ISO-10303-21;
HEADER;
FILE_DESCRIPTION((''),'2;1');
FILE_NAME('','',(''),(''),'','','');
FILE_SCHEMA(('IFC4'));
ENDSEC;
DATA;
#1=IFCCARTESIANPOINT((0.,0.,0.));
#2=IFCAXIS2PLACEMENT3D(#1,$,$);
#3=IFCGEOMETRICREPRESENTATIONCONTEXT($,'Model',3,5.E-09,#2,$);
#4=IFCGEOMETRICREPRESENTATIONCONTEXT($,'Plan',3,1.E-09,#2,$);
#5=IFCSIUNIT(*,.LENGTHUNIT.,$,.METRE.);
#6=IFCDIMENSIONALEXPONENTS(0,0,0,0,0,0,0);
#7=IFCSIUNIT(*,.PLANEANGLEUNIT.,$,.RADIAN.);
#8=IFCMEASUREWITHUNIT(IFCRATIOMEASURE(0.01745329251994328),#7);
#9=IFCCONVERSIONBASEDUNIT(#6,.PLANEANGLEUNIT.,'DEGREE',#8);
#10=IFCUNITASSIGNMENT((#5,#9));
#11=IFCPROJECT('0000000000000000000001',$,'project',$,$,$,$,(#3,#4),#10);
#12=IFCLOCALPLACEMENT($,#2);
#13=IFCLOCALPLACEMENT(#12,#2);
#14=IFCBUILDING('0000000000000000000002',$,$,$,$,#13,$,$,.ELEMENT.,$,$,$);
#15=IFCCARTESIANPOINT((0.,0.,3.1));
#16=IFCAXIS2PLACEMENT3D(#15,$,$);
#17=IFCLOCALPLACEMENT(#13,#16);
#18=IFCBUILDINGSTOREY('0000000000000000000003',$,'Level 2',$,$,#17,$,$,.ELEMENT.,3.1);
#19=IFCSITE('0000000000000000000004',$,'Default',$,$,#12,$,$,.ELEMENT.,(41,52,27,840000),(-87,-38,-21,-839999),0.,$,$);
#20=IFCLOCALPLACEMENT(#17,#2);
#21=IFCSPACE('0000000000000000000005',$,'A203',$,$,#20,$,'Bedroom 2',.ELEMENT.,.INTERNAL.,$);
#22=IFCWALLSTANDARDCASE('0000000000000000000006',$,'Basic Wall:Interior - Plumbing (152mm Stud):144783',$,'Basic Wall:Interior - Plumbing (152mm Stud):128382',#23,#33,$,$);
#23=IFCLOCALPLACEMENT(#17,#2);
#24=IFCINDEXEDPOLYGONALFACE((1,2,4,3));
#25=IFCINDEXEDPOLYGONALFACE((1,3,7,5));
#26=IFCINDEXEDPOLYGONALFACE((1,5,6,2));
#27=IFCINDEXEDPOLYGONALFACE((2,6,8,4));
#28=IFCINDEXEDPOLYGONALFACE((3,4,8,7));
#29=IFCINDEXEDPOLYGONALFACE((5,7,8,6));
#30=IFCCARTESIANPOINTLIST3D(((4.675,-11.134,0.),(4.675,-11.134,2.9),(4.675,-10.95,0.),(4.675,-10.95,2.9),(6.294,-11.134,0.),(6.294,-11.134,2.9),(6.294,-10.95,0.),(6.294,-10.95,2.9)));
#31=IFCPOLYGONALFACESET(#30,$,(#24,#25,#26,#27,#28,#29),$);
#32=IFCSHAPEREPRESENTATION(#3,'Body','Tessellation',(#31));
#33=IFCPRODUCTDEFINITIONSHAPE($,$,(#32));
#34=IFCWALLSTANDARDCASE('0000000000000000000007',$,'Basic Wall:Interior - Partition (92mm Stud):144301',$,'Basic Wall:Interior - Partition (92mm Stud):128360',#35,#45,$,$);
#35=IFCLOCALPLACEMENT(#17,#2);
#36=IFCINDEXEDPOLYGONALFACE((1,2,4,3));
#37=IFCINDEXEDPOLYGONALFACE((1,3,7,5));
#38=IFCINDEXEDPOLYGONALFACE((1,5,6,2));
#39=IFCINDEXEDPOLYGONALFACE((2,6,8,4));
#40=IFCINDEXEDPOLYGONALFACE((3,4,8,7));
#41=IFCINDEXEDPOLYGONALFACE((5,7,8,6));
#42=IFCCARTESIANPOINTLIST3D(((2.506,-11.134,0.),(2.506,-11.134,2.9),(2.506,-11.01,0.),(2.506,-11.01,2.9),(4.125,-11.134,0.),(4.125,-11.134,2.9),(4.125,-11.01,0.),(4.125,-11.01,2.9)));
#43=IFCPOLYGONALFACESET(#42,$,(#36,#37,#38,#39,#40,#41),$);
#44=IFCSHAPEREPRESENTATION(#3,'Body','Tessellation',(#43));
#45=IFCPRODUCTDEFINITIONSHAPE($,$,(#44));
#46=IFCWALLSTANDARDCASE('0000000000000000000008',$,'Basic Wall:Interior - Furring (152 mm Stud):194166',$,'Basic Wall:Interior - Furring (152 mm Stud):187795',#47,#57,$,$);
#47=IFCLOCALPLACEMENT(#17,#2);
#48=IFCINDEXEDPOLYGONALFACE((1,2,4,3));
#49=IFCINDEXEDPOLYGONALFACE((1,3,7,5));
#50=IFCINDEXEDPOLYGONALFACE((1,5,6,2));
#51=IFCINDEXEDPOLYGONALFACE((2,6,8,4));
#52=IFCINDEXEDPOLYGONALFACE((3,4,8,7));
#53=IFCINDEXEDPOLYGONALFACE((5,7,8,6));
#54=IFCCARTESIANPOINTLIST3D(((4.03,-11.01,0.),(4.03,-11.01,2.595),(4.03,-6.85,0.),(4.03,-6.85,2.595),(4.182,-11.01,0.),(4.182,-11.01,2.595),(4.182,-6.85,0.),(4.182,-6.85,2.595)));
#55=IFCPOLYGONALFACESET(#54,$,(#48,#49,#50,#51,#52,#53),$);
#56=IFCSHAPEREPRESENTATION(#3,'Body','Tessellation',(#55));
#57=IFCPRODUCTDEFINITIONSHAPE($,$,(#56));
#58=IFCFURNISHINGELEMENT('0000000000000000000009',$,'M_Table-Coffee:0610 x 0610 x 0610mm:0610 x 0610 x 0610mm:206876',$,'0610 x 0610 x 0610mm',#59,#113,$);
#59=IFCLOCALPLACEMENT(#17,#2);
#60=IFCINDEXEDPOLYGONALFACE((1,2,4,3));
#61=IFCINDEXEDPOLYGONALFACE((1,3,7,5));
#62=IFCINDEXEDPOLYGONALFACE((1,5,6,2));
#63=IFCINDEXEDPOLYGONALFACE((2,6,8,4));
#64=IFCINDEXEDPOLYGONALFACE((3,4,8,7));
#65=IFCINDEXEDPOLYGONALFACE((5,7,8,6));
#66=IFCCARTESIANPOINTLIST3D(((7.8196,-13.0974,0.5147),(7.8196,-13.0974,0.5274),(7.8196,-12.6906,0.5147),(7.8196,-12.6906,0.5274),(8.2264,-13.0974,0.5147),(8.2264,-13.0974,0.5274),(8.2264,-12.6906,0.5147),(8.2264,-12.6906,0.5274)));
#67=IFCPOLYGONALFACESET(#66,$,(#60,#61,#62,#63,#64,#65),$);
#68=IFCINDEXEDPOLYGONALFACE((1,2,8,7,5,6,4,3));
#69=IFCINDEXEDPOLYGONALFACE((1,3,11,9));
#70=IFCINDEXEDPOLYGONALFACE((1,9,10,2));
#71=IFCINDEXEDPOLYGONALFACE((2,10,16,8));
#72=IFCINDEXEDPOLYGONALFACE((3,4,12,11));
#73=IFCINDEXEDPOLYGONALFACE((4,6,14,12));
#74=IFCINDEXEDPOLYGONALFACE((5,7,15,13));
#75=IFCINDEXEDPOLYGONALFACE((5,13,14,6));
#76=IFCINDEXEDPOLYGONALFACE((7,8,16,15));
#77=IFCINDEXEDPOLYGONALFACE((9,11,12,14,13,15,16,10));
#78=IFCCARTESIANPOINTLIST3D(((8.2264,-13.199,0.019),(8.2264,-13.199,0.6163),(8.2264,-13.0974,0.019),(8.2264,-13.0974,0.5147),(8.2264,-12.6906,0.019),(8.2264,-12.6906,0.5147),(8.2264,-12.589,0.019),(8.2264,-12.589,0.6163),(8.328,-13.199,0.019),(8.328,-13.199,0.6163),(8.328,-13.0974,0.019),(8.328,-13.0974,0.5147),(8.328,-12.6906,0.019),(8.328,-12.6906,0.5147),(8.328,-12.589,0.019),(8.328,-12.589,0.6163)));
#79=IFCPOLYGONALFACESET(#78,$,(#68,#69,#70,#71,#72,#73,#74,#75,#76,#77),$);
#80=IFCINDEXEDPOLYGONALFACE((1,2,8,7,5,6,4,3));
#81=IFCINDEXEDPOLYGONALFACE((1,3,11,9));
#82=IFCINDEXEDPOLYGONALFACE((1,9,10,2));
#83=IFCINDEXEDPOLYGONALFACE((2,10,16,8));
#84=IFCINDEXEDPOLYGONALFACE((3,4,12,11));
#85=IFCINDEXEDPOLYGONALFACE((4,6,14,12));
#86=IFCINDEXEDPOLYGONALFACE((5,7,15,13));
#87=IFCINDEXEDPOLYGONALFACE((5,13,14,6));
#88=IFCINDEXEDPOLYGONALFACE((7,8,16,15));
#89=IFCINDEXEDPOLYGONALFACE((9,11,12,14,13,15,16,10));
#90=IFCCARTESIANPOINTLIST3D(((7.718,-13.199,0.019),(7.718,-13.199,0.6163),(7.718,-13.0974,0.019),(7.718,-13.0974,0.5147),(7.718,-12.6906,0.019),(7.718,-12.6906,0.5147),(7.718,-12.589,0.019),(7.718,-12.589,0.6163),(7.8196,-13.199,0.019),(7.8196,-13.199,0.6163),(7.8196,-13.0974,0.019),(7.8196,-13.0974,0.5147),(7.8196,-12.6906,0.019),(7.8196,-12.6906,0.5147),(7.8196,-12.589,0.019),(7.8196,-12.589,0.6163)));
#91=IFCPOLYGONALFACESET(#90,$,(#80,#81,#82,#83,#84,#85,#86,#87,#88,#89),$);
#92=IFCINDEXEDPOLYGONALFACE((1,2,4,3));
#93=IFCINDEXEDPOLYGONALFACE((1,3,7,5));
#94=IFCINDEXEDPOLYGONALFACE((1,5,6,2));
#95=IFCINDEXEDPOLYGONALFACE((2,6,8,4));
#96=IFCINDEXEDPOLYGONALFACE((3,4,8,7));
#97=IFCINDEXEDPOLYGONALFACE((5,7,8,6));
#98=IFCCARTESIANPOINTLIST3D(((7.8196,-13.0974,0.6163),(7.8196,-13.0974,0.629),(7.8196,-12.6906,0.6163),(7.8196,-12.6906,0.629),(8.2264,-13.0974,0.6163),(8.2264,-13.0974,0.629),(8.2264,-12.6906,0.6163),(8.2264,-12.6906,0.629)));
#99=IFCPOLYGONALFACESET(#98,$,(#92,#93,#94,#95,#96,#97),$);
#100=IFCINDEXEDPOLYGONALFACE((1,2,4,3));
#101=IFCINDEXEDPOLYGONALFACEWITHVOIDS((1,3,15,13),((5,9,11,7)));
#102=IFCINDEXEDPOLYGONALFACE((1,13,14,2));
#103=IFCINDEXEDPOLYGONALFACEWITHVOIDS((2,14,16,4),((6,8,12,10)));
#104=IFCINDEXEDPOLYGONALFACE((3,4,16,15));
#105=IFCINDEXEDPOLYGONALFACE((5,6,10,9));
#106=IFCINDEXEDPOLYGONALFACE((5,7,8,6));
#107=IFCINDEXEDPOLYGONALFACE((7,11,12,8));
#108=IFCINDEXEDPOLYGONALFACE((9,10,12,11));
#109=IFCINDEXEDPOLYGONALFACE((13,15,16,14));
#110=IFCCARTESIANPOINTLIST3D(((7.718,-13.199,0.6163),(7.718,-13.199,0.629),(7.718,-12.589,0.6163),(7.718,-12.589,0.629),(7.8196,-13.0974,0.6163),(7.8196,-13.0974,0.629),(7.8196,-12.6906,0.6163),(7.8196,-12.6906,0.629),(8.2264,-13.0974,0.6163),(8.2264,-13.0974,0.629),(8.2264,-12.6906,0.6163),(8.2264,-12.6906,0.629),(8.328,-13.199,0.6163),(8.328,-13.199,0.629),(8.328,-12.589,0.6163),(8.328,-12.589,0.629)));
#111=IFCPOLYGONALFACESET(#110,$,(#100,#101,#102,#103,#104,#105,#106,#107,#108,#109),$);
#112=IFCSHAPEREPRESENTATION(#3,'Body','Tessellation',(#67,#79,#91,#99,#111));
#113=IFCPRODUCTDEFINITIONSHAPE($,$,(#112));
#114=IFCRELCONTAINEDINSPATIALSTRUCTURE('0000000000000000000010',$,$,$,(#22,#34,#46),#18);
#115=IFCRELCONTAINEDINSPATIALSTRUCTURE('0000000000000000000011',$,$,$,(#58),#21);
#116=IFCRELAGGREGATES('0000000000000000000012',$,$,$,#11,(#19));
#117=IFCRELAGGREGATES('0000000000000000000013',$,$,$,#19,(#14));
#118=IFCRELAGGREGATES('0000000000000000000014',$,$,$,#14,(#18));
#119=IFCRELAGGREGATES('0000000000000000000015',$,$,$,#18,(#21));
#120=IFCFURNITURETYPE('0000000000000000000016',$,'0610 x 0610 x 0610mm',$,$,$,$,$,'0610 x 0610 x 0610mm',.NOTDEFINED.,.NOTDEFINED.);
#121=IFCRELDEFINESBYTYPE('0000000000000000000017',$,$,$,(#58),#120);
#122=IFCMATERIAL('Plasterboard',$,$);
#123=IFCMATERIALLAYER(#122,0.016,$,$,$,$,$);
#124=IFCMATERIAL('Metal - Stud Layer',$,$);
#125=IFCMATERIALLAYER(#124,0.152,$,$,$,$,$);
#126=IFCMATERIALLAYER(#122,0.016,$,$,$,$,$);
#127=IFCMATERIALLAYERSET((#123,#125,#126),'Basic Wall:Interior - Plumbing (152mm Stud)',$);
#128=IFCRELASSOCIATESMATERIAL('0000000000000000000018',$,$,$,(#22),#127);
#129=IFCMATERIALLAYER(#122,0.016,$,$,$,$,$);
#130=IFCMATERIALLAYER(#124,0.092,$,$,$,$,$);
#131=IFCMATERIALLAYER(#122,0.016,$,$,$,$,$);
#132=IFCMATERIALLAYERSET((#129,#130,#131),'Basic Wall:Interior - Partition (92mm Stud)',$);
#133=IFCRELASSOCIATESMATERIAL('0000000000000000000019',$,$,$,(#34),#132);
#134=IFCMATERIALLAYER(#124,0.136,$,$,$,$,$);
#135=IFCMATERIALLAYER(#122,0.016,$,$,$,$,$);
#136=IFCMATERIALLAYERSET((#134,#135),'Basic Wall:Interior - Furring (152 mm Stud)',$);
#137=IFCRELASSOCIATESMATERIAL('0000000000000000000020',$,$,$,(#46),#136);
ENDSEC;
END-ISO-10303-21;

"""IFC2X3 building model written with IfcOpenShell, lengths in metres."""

from ifc_helpers import new_model, entity, si_unit, converted_unit, frame, frame_2d, origin, origin_2d_with_axis, place, context, project, spatial, polyline, rectangle, outline, extrude, source, transform, mapped, material, layer, layer_set, layer_usage, type_object, type_shapes, element, save


model = new_model("IFC2X3")

# Units and contexts
model_context = context("Model", 3, precision=5e-09, world=origin())
plan_context = context("Plan", 3, precision=1e-09, world=origin())
ifc_project = project(units=[si_unit("LENGTHUNIT", "METRE"), converted_unit("PLANEANGLEUNIT", "DEGREE", entity("IfcRatioMeasure", 0.01745329251994328), si_unit("PLANEANGLEUNIT", "RADIAN"), dimensions=[0, 0, 0, 0, 0, 0, 0])], contexts=[model_context, plan_context])

# Site, building, storey
site_placement = place(None, origin())
site = spatial("IfcSite", under=ifc_project, at=site_placement, Name="Default", CompositionType="ELEMENT", RefLatitude=(41, 52, 27, 840000), RefLongitude=(-87, -38, -21, -839999), RefElevation=0.0)
building_placement = place(site_placement, origin())
building = spatial("IfcBuilding", under=site, at=building_placement, CompositionType="ELEMENT")
storey_placement = place(building_placement, frame((0.0, 0.0, 3.1)))
storey = spatial("IfcBuildingStorey", under=building, at=storey_placement, Name="Level 2", CompositionType="ELEMENT", Elevation=3.1)

# Shared definitions
ifc_material_1 = material(Name="Plasterboard")
ifc_layer_1 = layer(ifc_material_1, 0.016)
ifc_material_2 = material(Name="Metal - Stud Layer")
ifc_layer_2 = layer(ifc_material_2, 0.092)
ifc_layer_3 = layer(ifc_material_1, 0.016)
ifc_layer_set_1 = layer_set([ifc_layer_1, ifc_layer_2, ifc_layer_3], Name="Basic Wall:Interior - Partition (92mm Stud)")
ifc_layer_usage_1 = layer_usage(ifc_layer_set_1, "AXIS2", "NEGATIVE", 0.062)

# Walls
ifc_layer_4 = layer(ifc_material_1, 0.016)
ifc_layer_5 = layer(ifc_material_2, 0.152)
ifc_layer_6 = layer(ifc_material_1, 0.016)
ifc_layer_set_2 = layer_set([ifc_layer_4, ifc_layer_5, ifc_layer_6], Name="Basic Wall:Interior - Plumbing (152mm Stud)")
ifc_layer_usage_2 = layer_usage(ifc_layer_set_2, "AXIS2", "NEGATIVE", 0.092)
wall_1_placement = place(storey_placement, frame((6.294, -11.042, 0.0), z_axis=(0.0, 0.0, 1.0), x_axis=(-1.0, 0.0, 0.0)))
element("IfcWallStandardCase", 1, at=wall_1_placement, inside=storey, material=ifc_layer_usage_2, Name="Basic Wall:Interior - Plumbing (152mm Stud):144783", ObjectType="Basic Wall:Interior - Plumbing (152mm Stud):128382", context=model_context, shape_type="SweptSolid", body=[
    extrude(rectangle(XDim=1.619, YDim=0.184, at=frame_2d((0.8095, 0.0), x_axis=(-1.0, 0.0))), origin(), (0.0, 0.0, 1.0), 2.9),
])
wall_2_placement = place(storey_placement, frame((4.125, -11.072, 0.0), z_axis=(0.0, 0.0, 1.0), x_axis=(-1.0, 0.0, 0.0)))
element("IfcWallStandardCase", 2, at=wall_2_placement, inside=storey, material=ifc_layer_usage_1, Name="Basic Wall:Interior - Partition (92mm Stud):144301", ObjectType="Basic Wall:Interior - Partition (92mm Stud):128360", context=model_context, shape_type="SweptSolid", body=[
    extrude(rectangle(XDim=1.619, YDim=0.124, at=frame_2d((0.8095, 0.0), x_axis=(-1.0, 0.0))), origin(), (0.0, 0.0, 1.0), 2.9),
])
ifc_layer_7 = layer(ifc_material_2, 0.136)
ifc_layer_8 = layer(ifc_material_1, 0.016)
ifc_layer_set_3 = layer_set([ifc_layer_7, ifc_layer_8], Name="Basic Wall:Interior - Furring (152 mm Stud)")
ifc_layer_usage_3 = layer_usage(ifc_layer_set_3, "AXIS2", "POSITIVE", -0.076)
wall_3_placement = place(storey_placement, frame((4.106, -11.01, 0.0), z_axis=(0.0, 0.0, 1.0), x_axis=(0.0, 1.0, 0.0)))
element("IfcWallStandardCase", 3, at=wall_3_placement, inside=storey, material=ifc_layer_usage_3, Name="Basic Wall:Interior - Furring (152 mm Stud):194166", ObjectType="Basic Wall:Interior - Furring (152 mm Stud):187795", context=model_context, shape_type="SweptSolid", body=[
    extrude(rectangle(XDim=4.16, YDim=0.152, at=frame_2d((2.08, 0.0), x_axis=(-1.0, 0.0))), origin(), (0.0, 0.0, 1.0), 2.595),
])

# Shared definitions
space_placement = place(storey_placement, origin())
space = spatial("IfcSpace", under=storey, at=space_placement, Name="A203", LongName="Bedroom 2", CompositionType="ELEMENT", InteriorOrExteriorSpace="INTERNAL")

# Furnishing element
furniture_type = type_object("IfcFurnitureType", Name="0610 x 0610 x 0610mm", ElementType="0610 x 0610 x 0610mm", AssemblyPlace="NOTDEFINED")
shared_shape_1 = source(origin(), model_context, "Body", "SweptSolid", [
    extrude(rectangle(XDim=0.4068, YDim=0.4068, at=origin_2d_with_axis()), frame((0.0183, 0.0952, 0.4957), z_axis=(0.0, 0.0, 1.0), x_axis=(-1.0, 0.0, 0.0)), (0.0, 0.0, 1.0), 0.0127),
    extrude(outline(polyline([(-0.2732, -0.305), (0.324, -0.305), (0.324, 0.305), (-0.2732, 0.305), (-0.2732, 0.2034), (0.2225, 0.2034), (0.2225, -0.2034), (-0.2732, -0.2034), (-0.2732, -0.305)])), frame((0.2217, 0.0952, 0.2732), z_axis=(1.0, 0.0, 0.0), x_axis=(0.0, 0.0, 1.0)), (0.0, 0.0, 1.0), 0.1016),
    extrude(outline(polyline([(-0.305, -0.3241), (0.305, -0.3241), (0.305, 0.2733), (0.2034, 0.2733), (0.2034, -0.2224), (-0.2034, -0.2224), (-0.2034, 0.2733), (-0.305, 0.2733), (-0.305, -0.3241)])), frame((-0.2867, 0.0952, 0.2733), z_axis=(1.0, 0.0, 0.0), x_axis=(0.0, -1.0, 0.0)), (0.0, 0.0, 1.0), 0.1016),
    extrude(rectangle(XDim=0.4068, YDim=0.4068, at=origin_2d_with_axis()), frame((0.0183, 0.0952, 0.5973), z_axis=(0.0, 0.0, 1.0), x_axis=(-1.0, 0.0, 0.0)), (0.0, 0.0, 1.0), 0.0127),
    extrude(outline(polyline([(-0.305, -0.305), (0.305, -0.305), (0.305, 0.305), (-0.305, 0.305), (-0.305, -0.305)]), holes=[polyline([(-0.2034, -0.2034), (-0.2034, 0.2034), (0.2034, 0.2034), (0.2034, -0.2034), (-0.2034, -0.2034)])]), frame((0.0183, 0.0952, 0.5973), z_axis=(0.0, 0.0, 1.0), x_axis=(-1.0, 0.0, 0.0)), (0.0, 0.0, 1.0), 0.0127),
])
type_shapes(furniture_type, [shared_shape_1])
furnishing_placement = place(space_placement, frame((8.0047, -12.9892, 0.019)))
element("IfcFurnishingElement", 4, at=furnishing_placement, inside=space, type_object=furniture_type, Name="M_Table-Coffee:0610 x 0610 x 0610mm:0610 x 0610 x 0610mm:206876", ObjectType="0610 x 0610 x 0610mm", context=model_context, shape_type="MappedRepresentation", body=[
    mapped(shared_shape_1, transform((0.0, 0.0, 0.0), scale=1.0)),
])

save(model, "model.ifc")
